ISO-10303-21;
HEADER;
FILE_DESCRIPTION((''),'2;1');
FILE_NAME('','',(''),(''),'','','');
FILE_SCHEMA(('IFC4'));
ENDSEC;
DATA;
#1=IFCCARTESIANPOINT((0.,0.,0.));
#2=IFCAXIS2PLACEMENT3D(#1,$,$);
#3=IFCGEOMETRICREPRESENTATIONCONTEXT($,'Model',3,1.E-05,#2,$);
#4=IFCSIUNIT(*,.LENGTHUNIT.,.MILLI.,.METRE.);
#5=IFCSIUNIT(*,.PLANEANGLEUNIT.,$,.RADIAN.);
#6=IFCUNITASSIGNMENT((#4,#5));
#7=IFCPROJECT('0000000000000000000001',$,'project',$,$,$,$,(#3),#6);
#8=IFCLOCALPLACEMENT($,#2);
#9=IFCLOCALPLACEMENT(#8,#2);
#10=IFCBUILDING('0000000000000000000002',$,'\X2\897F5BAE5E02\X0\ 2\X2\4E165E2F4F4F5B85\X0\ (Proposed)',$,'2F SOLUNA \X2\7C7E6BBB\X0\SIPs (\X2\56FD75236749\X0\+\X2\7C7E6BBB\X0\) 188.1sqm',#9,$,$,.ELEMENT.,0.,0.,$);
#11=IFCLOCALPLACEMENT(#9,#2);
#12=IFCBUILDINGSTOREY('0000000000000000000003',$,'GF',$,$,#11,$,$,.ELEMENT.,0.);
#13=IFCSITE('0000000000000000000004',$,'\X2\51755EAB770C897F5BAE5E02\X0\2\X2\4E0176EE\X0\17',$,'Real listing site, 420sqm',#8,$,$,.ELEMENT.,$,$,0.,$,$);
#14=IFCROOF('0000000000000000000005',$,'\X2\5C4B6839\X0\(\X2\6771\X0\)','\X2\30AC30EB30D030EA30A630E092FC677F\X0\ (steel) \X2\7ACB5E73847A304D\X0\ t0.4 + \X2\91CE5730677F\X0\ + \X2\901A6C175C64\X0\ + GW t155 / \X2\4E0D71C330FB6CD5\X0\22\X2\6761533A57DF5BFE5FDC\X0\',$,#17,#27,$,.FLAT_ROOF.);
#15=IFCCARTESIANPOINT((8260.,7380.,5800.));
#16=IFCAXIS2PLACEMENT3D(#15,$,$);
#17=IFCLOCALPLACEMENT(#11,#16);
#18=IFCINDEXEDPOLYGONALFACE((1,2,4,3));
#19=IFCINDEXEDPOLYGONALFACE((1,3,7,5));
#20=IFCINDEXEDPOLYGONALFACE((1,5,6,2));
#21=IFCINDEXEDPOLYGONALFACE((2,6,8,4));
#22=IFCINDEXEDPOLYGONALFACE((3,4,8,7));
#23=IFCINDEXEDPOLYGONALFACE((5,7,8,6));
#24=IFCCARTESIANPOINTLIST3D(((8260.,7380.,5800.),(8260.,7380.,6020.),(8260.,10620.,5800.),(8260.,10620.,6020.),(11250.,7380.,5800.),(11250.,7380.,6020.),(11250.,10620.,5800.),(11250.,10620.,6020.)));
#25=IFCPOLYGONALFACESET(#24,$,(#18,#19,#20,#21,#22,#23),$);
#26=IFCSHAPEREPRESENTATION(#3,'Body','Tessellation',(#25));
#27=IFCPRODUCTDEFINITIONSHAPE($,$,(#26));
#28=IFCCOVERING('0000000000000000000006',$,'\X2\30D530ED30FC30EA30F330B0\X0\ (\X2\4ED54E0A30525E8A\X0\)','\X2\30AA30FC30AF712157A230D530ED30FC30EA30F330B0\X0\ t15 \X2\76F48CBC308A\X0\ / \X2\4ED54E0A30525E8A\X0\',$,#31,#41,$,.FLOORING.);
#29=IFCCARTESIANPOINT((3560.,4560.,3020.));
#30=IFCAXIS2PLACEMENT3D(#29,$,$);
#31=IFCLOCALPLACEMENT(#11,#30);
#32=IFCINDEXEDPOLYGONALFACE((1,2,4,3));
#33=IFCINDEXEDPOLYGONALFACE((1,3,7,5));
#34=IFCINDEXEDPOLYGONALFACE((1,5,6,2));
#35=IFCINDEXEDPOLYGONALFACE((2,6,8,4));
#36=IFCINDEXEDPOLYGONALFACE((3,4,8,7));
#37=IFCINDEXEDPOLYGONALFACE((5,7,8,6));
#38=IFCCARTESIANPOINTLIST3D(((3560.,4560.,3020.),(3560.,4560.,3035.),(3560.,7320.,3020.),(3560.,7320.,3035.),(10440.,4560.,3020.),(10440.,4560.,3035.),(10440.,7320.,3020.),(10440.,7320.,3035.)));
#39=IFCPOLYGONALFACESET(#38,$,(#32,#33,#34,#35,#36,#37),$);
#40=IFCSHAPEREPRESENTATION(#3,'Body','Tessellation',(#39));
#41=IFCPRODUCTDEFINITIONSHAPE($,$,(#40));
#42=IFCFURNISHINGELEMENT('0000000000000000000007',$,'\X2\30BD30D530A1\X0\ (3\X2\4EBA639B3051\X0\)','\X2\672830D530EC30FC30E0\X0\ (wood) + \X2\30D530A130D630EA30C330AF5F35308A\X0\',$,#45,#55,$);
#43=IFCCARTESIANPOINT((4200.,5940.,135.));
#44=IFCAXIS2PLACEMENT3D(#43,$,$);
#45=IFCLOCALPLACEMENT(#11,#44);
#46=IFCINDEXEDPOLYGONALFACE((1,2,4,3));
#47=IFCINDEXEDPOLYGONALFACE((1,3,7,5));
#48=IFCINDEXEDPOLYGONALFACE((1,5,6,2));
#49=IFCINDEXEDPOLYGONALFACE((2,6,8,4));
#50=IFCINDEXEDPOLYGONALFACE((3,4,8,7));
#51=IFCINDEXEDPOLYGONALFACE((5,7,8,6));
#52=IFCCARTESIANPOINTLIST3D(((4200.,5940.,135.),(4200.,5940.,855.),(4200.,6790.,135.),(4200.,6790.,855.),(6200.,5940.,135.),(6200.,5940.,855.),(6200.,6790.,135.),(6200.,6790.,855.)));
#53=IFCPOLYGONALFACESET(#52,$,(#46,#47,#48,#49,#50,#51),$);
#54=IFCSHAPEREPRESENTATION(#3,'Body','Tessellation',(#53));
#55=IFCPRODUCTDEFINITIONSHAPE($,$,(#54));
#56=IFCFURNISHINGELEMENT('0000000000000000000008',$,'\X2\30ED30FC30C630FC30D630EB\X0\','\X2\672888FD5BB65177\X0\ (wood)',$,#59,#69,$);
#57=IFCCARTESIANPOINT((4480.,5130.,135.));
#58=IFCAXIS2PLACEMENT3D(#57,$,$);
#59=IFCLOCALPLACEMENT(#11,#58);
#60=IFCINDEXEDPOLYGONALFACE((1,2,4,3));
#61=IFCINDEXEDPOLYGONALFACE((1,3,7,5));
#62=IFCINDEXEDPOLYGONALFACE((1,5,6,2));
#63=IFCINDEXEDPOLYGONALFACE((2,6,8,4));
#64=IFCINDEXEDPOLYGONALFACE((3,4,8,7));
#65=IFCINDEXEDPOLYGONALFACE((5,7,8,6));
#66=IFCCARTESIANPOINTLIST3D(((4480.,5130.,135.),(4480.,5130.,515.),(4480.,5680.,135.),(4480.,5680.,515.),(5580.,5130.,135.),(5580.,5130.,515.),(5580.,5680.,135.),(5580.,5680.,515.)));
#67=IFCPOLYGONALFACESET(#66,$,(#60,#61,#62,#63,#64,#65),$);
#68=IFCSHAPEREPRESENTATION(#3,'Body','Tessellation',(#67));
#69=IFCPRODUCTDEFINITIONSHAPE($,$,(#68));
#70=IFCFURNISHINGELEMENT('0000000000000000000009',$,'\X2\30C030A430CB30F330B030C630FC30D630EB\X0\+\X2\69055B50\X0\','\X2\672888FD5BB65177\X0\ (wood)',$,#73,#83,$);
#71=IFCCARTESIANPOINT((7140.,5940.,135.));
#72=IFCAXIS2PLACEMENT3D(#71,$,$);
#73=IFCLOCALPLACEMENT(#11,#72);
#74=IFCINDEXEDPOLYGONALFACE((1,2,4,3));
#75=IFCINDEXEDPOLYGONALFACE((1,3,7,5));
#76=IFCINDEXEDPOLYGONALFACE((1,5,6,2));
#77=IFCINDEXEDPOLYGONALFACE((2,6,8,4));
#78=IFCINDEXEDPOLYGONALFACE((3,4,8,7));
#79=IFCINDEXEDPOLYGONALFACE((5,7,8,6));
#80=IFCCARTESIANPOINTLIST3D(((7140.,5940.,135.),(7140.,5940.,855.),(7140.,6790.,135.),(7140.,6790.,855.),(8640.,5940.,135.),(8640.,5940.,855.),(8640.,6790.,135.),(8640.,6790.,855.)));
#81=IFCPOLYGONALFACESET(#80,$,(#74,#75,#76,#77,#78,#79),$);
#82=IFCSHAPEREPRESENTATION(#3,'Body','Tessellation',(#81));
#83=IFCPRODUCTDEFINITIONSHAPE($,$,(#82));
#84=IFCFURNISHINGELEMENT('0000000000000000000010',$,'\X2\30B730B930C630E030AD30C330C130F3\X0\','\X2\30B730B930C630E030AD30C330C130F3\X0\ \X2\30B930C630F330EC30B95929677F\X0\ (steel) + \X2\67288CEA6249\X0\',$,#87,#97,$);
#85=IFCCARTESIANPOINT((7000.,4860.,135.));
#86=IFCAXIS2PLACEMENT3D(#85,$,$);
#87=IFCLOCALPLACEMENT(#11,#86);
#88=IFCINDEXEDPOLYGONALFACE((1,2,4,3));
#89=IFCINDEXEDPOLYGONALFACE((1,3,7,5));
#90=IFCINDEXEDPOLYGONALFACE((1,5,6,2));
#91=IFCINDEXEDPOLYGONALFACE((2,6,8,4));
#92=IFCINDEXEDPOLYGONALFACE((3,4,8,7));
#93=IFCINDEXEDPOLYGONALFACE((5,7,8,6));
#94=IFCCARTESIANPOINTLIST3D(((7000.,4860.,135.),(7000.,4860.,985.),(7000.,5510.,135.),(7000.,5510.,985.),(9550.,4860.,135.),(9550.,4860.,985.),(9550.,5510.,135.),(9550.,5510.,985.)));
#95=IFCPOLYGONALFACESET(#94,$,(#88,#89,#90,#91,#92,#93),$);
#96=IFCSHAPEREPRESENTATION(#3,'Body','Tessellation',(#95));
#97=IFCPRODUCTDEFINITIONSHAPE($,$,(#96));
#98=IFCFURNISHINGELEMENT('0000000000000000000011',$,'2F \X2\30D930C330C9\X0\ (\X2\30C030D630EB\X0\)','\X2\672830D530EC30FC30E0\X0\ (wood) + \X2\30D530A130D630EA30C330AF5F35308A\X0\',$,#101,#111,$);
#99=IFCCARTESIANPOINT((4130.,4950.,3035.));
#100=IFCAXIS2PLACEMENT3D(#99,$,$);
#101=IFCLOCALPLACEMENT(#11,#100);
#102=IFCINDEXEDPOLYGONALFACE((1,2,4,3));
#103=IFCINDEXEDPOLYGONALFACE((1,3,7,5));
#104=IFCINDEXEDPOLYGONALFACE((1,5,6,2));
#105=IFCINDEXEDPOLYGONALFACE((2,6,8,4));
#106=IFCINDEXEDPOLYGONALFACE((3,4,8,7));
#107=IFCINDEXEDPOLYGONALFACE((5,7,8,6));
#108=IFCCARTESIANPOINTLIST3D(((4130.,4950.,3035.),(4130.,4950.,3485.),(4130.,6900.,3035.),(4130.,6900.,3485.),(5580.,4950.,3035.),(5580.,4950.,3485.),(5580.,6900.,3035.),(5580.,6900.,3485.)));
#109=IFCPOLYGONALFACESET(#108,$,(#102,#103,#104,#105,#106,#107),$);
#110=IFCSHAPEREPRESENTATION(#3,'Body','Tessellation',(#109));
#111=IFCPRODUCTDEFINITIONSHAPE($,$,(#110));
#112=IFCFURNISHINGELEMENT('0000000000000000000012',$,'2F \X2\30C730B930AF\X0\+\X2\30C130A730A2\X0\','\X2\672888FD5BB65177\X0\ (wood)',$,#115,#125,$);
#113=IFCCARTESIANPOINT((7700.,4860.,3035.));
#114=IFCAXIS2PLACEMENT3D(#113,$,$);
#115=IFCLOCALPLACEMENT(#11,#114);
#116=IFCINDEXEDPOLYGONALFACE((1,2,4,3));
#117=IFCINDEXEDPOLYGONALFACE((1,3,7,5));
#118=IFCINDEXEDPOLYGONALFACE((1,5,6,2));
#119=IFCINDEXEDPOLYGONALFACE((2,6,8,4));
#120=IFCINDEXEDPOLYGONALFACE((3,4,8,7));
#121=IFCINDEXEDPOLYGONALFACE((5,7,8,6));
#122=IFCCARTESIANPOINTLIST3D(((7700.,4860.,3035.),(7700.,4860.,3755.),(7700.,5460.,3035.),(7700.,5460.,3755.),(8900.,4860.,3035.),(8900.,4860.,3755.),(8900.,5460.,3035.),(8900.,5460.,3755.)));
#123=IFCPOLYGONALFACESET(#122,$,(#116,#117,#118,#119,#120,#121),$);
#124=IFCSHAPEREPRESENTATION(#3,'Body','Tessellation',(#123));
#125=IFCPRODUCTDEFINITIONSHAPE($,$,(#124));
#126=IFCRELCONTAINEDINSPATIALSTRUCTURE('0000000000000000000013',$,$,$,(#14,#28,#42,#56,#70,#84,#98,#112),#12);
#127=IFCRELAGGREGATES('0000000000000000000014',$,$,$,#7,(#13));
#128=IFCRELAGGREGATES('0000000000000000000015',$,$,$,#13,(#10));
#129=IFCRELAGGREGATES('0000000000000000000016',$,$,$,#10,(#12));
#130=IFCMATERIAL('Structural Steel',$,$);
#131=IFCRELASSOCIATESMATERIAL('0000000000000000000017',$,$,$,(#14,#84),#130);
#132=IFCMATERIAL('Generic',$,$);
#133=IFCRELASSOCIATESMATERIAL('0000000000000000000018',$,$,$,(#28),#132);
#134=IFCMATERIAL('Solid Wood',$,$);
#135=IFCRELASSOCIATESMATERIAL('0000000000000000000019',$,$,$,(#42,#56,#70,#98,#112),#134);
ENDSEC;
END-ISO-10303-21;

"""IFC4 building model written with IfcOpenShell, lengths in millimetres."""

from ifc_helpers import new_model, si_unit, frame, frame_2d, origin, place, context, project, spatial, rectangle, extrude, material, element, save


model = new_model("IFC4")

# Units and contexts
model_context = context("Model", 3, precision=1e-05, world=origin())
ifc_project = project(units=[si_unit("LENGTHUNIT", "METRE", prefix="MILLI"), si_unit("PLANEANGLEUNIT", "RADIAN")], contexts=[model_context])

# Site, building, storey
site_placement = place(None, origin())
site = spatial("IfcSite", under=ifc_project, at=site_placement, Name="兵庫県西宮市2丁目17", ObjectType="Real listing site, 420sqm", CompositionType="ELEMENT", RefElevation=0.0)
building_placement = place(site_placement, origin())
building = spatial("IfcBuilding", under=site, at=building_placement, Name="西宮市 2世帯住宅 (Proposed)", ObjectType="2F SOLUNA 籾殻SIPs (国産杉+籾殻) 188.1sqm", CompositionType="ELEMENT", ElevationOfRefHeight=0.0, ElevationOfTerrain=0.0)
storey_placement = place(building_placement, origin())
storey = spatial("IfcBuildingStorey", under=building, at=storey_placement, Name="GF", CompositionType="ELEMENT", Elevation=0.0)

# Shared definitions
ifc_material_1 = material(Name="Solid Wood")

# Shared definitions
ifc_material_2 = material(Name="Generic")

# Roof
ifc_material_3 = material(Name="Structural Steel")
roof_placement = place(storey_placement, frame((8260.0, 7380.0, 5800.0)))
element("IfcRoof", 1, at=roof_placement, inside=storey, material=ifc_material_3, Name="屋根(東)", Description="ガルバリウム鋼板 (steel) 立平葺き t0.4 + 野地板 + 通気層 + GW t155 / 不燃・法22条区域対応", PredefinedType="FLAT_ROOF", context=model_context, shape_type="SweptSolid", body=[
    extrude(rectangle(XDim=2990.0, YDim=3240.0, at=frame_2d((1495.0, 1620.0))), frame((8260.0, 7380.0, 5800.0)), (0.0, 0.0, 1.0), 220.0),
])

# Covering
covering_placement = place(storey_placement, frame((3560.0, 4560.0, 3020.0)))
element("IfcCovering", 2, at=covering_placement, inside=storey, material=ifc_material_2, Name="フローリング (仕上げ床)", Description="オーク無垢フローリング t15 直貼り / 仕上げ床", PredefinedType="FLOORING", context=model_context, shape_type="SweptSolid", body=[
    extrude(rectangle(XDim=6880.0, YDim=2760.0, at=frame_2d((3440.0, 1380.0))), frame((3560.0, 4560.0, 3020.0)), (0.0, 0.0, 1.0), 15.0),
])

# Furnishing elements
furnishing_1_placement = place(storey_placement, frame((4200.0, 5940.0, 135.0)))
element("IfcFurnishingElement", 3, at=furnishing_1_placement, inside=storey, material=ifc_material_1, Name="ソファ (3人掛け)", Description="木フレーム (wood) + ファブリック張り", context=model_context, shape_type="SweptSolid", body=[
    extrude(rectangle(XDim=2000.0, YDim=850.0, at=frame_2d((1000.0, 425.0))), frame((4200.0, 5940.0, 135.0)), (0.0, 0.0, 1.0), 720.0),
])
furnishing_2_placement = place(storey_placement, frame((4480.0, 5130.0, 135.0)))
element("IfcFurnishingElement", 4, at=furnishing_2_placement, inside=storey, material=ifc_material_1, Name="ローテーブル", Description="木製家具 (wood)", context=model_context, shape_type="SweptSolid", body=[
    extrude(rectangle(XDim=1100.0, YDim=550.0, at=frame_2d((550.0, 275.0))), frame((4480.0, 5130.0, 135.0)), (0.0, 0.0, 1.0), 380.0),
])
furnishing_3_placement = place(storey_placement, frame((7140.0, 5940.0, 135.0)))
element("IfcFurnishingElement", 5, at=furnishing_3_placement, inside=storey, material=ifc_material_1, Name="ダイニングテーブル+椅子", Description="木製家具 (wood)", context=model_context, shape_type="SweptSolid", body=[
    extrude(rectangle(XDim=1500.0, YDim=850.0, at=frame_2d((750.0, 425.0))), frame((7140.0, 5940.0, 135.0)), (0.0, 0.0, 1.0), 720.0),
])
furnishing_4_placement = place(storey_placement, frame((7000.0, 4860.0, 135.0)))
element("IfcFurnishingElement", 6, at=furnishing_4_placement, inside=storey, material=ifc_material_3, Name="システムキッチン", Description="システムキッチン ステンレス天板 (steel) + 木質扉", context=model_context, shape_type="SweptSolid", body=[
    extrude(rectangle(XDim=2550.0, YDim=650.0, at=frame_2d((1275.0, 325.0))), frame((7000.0, 4860.0, 135.0)), (0.0, 0.0, 1.0), 850.0),
])
furnishing_5_placement = place(storey_placement, frame((4130.0, 4950.0, 3035.0)))
element("IfcFurnishingElement", 7, at=furnishing_5_placement, inside=storey, material=ifc_material_1, Name="2F ベッド (ダブル)", Description="木フレーム (wood) + ファブリック張り", context=model_context, shape_type="SweptSolid", body=[
    extrude(rectangle(XDim=1450.0, YDim=1950.0, at=frame_2d((725.0, 975.0))), frame((4130.0, 4950.0, 3035.0)), (0.0, 0.0, 1.0), 450.0),
])
furnishing_6_placement = place(storey_placement, frame((7700.0, 4860.0, 3035.0)))
element("IfcFurnishingElement", 8, at=furnishing_6_placement, inside=storey, material=ifc_material_1, Name="2F デスク+チェア", Description="木製家具 (wood)", context=model_context, shape_type="SweptSolid", body=[
    extrude(rectangle(XDim=1200.0, YDim=600.0, at=frame_2d((600.0, 300.0))), frame((7700.0, 4860.0, 3035.0)), (0.0, 0.0, 1.0), 720.0),
])

save(model, "model.ifc")
